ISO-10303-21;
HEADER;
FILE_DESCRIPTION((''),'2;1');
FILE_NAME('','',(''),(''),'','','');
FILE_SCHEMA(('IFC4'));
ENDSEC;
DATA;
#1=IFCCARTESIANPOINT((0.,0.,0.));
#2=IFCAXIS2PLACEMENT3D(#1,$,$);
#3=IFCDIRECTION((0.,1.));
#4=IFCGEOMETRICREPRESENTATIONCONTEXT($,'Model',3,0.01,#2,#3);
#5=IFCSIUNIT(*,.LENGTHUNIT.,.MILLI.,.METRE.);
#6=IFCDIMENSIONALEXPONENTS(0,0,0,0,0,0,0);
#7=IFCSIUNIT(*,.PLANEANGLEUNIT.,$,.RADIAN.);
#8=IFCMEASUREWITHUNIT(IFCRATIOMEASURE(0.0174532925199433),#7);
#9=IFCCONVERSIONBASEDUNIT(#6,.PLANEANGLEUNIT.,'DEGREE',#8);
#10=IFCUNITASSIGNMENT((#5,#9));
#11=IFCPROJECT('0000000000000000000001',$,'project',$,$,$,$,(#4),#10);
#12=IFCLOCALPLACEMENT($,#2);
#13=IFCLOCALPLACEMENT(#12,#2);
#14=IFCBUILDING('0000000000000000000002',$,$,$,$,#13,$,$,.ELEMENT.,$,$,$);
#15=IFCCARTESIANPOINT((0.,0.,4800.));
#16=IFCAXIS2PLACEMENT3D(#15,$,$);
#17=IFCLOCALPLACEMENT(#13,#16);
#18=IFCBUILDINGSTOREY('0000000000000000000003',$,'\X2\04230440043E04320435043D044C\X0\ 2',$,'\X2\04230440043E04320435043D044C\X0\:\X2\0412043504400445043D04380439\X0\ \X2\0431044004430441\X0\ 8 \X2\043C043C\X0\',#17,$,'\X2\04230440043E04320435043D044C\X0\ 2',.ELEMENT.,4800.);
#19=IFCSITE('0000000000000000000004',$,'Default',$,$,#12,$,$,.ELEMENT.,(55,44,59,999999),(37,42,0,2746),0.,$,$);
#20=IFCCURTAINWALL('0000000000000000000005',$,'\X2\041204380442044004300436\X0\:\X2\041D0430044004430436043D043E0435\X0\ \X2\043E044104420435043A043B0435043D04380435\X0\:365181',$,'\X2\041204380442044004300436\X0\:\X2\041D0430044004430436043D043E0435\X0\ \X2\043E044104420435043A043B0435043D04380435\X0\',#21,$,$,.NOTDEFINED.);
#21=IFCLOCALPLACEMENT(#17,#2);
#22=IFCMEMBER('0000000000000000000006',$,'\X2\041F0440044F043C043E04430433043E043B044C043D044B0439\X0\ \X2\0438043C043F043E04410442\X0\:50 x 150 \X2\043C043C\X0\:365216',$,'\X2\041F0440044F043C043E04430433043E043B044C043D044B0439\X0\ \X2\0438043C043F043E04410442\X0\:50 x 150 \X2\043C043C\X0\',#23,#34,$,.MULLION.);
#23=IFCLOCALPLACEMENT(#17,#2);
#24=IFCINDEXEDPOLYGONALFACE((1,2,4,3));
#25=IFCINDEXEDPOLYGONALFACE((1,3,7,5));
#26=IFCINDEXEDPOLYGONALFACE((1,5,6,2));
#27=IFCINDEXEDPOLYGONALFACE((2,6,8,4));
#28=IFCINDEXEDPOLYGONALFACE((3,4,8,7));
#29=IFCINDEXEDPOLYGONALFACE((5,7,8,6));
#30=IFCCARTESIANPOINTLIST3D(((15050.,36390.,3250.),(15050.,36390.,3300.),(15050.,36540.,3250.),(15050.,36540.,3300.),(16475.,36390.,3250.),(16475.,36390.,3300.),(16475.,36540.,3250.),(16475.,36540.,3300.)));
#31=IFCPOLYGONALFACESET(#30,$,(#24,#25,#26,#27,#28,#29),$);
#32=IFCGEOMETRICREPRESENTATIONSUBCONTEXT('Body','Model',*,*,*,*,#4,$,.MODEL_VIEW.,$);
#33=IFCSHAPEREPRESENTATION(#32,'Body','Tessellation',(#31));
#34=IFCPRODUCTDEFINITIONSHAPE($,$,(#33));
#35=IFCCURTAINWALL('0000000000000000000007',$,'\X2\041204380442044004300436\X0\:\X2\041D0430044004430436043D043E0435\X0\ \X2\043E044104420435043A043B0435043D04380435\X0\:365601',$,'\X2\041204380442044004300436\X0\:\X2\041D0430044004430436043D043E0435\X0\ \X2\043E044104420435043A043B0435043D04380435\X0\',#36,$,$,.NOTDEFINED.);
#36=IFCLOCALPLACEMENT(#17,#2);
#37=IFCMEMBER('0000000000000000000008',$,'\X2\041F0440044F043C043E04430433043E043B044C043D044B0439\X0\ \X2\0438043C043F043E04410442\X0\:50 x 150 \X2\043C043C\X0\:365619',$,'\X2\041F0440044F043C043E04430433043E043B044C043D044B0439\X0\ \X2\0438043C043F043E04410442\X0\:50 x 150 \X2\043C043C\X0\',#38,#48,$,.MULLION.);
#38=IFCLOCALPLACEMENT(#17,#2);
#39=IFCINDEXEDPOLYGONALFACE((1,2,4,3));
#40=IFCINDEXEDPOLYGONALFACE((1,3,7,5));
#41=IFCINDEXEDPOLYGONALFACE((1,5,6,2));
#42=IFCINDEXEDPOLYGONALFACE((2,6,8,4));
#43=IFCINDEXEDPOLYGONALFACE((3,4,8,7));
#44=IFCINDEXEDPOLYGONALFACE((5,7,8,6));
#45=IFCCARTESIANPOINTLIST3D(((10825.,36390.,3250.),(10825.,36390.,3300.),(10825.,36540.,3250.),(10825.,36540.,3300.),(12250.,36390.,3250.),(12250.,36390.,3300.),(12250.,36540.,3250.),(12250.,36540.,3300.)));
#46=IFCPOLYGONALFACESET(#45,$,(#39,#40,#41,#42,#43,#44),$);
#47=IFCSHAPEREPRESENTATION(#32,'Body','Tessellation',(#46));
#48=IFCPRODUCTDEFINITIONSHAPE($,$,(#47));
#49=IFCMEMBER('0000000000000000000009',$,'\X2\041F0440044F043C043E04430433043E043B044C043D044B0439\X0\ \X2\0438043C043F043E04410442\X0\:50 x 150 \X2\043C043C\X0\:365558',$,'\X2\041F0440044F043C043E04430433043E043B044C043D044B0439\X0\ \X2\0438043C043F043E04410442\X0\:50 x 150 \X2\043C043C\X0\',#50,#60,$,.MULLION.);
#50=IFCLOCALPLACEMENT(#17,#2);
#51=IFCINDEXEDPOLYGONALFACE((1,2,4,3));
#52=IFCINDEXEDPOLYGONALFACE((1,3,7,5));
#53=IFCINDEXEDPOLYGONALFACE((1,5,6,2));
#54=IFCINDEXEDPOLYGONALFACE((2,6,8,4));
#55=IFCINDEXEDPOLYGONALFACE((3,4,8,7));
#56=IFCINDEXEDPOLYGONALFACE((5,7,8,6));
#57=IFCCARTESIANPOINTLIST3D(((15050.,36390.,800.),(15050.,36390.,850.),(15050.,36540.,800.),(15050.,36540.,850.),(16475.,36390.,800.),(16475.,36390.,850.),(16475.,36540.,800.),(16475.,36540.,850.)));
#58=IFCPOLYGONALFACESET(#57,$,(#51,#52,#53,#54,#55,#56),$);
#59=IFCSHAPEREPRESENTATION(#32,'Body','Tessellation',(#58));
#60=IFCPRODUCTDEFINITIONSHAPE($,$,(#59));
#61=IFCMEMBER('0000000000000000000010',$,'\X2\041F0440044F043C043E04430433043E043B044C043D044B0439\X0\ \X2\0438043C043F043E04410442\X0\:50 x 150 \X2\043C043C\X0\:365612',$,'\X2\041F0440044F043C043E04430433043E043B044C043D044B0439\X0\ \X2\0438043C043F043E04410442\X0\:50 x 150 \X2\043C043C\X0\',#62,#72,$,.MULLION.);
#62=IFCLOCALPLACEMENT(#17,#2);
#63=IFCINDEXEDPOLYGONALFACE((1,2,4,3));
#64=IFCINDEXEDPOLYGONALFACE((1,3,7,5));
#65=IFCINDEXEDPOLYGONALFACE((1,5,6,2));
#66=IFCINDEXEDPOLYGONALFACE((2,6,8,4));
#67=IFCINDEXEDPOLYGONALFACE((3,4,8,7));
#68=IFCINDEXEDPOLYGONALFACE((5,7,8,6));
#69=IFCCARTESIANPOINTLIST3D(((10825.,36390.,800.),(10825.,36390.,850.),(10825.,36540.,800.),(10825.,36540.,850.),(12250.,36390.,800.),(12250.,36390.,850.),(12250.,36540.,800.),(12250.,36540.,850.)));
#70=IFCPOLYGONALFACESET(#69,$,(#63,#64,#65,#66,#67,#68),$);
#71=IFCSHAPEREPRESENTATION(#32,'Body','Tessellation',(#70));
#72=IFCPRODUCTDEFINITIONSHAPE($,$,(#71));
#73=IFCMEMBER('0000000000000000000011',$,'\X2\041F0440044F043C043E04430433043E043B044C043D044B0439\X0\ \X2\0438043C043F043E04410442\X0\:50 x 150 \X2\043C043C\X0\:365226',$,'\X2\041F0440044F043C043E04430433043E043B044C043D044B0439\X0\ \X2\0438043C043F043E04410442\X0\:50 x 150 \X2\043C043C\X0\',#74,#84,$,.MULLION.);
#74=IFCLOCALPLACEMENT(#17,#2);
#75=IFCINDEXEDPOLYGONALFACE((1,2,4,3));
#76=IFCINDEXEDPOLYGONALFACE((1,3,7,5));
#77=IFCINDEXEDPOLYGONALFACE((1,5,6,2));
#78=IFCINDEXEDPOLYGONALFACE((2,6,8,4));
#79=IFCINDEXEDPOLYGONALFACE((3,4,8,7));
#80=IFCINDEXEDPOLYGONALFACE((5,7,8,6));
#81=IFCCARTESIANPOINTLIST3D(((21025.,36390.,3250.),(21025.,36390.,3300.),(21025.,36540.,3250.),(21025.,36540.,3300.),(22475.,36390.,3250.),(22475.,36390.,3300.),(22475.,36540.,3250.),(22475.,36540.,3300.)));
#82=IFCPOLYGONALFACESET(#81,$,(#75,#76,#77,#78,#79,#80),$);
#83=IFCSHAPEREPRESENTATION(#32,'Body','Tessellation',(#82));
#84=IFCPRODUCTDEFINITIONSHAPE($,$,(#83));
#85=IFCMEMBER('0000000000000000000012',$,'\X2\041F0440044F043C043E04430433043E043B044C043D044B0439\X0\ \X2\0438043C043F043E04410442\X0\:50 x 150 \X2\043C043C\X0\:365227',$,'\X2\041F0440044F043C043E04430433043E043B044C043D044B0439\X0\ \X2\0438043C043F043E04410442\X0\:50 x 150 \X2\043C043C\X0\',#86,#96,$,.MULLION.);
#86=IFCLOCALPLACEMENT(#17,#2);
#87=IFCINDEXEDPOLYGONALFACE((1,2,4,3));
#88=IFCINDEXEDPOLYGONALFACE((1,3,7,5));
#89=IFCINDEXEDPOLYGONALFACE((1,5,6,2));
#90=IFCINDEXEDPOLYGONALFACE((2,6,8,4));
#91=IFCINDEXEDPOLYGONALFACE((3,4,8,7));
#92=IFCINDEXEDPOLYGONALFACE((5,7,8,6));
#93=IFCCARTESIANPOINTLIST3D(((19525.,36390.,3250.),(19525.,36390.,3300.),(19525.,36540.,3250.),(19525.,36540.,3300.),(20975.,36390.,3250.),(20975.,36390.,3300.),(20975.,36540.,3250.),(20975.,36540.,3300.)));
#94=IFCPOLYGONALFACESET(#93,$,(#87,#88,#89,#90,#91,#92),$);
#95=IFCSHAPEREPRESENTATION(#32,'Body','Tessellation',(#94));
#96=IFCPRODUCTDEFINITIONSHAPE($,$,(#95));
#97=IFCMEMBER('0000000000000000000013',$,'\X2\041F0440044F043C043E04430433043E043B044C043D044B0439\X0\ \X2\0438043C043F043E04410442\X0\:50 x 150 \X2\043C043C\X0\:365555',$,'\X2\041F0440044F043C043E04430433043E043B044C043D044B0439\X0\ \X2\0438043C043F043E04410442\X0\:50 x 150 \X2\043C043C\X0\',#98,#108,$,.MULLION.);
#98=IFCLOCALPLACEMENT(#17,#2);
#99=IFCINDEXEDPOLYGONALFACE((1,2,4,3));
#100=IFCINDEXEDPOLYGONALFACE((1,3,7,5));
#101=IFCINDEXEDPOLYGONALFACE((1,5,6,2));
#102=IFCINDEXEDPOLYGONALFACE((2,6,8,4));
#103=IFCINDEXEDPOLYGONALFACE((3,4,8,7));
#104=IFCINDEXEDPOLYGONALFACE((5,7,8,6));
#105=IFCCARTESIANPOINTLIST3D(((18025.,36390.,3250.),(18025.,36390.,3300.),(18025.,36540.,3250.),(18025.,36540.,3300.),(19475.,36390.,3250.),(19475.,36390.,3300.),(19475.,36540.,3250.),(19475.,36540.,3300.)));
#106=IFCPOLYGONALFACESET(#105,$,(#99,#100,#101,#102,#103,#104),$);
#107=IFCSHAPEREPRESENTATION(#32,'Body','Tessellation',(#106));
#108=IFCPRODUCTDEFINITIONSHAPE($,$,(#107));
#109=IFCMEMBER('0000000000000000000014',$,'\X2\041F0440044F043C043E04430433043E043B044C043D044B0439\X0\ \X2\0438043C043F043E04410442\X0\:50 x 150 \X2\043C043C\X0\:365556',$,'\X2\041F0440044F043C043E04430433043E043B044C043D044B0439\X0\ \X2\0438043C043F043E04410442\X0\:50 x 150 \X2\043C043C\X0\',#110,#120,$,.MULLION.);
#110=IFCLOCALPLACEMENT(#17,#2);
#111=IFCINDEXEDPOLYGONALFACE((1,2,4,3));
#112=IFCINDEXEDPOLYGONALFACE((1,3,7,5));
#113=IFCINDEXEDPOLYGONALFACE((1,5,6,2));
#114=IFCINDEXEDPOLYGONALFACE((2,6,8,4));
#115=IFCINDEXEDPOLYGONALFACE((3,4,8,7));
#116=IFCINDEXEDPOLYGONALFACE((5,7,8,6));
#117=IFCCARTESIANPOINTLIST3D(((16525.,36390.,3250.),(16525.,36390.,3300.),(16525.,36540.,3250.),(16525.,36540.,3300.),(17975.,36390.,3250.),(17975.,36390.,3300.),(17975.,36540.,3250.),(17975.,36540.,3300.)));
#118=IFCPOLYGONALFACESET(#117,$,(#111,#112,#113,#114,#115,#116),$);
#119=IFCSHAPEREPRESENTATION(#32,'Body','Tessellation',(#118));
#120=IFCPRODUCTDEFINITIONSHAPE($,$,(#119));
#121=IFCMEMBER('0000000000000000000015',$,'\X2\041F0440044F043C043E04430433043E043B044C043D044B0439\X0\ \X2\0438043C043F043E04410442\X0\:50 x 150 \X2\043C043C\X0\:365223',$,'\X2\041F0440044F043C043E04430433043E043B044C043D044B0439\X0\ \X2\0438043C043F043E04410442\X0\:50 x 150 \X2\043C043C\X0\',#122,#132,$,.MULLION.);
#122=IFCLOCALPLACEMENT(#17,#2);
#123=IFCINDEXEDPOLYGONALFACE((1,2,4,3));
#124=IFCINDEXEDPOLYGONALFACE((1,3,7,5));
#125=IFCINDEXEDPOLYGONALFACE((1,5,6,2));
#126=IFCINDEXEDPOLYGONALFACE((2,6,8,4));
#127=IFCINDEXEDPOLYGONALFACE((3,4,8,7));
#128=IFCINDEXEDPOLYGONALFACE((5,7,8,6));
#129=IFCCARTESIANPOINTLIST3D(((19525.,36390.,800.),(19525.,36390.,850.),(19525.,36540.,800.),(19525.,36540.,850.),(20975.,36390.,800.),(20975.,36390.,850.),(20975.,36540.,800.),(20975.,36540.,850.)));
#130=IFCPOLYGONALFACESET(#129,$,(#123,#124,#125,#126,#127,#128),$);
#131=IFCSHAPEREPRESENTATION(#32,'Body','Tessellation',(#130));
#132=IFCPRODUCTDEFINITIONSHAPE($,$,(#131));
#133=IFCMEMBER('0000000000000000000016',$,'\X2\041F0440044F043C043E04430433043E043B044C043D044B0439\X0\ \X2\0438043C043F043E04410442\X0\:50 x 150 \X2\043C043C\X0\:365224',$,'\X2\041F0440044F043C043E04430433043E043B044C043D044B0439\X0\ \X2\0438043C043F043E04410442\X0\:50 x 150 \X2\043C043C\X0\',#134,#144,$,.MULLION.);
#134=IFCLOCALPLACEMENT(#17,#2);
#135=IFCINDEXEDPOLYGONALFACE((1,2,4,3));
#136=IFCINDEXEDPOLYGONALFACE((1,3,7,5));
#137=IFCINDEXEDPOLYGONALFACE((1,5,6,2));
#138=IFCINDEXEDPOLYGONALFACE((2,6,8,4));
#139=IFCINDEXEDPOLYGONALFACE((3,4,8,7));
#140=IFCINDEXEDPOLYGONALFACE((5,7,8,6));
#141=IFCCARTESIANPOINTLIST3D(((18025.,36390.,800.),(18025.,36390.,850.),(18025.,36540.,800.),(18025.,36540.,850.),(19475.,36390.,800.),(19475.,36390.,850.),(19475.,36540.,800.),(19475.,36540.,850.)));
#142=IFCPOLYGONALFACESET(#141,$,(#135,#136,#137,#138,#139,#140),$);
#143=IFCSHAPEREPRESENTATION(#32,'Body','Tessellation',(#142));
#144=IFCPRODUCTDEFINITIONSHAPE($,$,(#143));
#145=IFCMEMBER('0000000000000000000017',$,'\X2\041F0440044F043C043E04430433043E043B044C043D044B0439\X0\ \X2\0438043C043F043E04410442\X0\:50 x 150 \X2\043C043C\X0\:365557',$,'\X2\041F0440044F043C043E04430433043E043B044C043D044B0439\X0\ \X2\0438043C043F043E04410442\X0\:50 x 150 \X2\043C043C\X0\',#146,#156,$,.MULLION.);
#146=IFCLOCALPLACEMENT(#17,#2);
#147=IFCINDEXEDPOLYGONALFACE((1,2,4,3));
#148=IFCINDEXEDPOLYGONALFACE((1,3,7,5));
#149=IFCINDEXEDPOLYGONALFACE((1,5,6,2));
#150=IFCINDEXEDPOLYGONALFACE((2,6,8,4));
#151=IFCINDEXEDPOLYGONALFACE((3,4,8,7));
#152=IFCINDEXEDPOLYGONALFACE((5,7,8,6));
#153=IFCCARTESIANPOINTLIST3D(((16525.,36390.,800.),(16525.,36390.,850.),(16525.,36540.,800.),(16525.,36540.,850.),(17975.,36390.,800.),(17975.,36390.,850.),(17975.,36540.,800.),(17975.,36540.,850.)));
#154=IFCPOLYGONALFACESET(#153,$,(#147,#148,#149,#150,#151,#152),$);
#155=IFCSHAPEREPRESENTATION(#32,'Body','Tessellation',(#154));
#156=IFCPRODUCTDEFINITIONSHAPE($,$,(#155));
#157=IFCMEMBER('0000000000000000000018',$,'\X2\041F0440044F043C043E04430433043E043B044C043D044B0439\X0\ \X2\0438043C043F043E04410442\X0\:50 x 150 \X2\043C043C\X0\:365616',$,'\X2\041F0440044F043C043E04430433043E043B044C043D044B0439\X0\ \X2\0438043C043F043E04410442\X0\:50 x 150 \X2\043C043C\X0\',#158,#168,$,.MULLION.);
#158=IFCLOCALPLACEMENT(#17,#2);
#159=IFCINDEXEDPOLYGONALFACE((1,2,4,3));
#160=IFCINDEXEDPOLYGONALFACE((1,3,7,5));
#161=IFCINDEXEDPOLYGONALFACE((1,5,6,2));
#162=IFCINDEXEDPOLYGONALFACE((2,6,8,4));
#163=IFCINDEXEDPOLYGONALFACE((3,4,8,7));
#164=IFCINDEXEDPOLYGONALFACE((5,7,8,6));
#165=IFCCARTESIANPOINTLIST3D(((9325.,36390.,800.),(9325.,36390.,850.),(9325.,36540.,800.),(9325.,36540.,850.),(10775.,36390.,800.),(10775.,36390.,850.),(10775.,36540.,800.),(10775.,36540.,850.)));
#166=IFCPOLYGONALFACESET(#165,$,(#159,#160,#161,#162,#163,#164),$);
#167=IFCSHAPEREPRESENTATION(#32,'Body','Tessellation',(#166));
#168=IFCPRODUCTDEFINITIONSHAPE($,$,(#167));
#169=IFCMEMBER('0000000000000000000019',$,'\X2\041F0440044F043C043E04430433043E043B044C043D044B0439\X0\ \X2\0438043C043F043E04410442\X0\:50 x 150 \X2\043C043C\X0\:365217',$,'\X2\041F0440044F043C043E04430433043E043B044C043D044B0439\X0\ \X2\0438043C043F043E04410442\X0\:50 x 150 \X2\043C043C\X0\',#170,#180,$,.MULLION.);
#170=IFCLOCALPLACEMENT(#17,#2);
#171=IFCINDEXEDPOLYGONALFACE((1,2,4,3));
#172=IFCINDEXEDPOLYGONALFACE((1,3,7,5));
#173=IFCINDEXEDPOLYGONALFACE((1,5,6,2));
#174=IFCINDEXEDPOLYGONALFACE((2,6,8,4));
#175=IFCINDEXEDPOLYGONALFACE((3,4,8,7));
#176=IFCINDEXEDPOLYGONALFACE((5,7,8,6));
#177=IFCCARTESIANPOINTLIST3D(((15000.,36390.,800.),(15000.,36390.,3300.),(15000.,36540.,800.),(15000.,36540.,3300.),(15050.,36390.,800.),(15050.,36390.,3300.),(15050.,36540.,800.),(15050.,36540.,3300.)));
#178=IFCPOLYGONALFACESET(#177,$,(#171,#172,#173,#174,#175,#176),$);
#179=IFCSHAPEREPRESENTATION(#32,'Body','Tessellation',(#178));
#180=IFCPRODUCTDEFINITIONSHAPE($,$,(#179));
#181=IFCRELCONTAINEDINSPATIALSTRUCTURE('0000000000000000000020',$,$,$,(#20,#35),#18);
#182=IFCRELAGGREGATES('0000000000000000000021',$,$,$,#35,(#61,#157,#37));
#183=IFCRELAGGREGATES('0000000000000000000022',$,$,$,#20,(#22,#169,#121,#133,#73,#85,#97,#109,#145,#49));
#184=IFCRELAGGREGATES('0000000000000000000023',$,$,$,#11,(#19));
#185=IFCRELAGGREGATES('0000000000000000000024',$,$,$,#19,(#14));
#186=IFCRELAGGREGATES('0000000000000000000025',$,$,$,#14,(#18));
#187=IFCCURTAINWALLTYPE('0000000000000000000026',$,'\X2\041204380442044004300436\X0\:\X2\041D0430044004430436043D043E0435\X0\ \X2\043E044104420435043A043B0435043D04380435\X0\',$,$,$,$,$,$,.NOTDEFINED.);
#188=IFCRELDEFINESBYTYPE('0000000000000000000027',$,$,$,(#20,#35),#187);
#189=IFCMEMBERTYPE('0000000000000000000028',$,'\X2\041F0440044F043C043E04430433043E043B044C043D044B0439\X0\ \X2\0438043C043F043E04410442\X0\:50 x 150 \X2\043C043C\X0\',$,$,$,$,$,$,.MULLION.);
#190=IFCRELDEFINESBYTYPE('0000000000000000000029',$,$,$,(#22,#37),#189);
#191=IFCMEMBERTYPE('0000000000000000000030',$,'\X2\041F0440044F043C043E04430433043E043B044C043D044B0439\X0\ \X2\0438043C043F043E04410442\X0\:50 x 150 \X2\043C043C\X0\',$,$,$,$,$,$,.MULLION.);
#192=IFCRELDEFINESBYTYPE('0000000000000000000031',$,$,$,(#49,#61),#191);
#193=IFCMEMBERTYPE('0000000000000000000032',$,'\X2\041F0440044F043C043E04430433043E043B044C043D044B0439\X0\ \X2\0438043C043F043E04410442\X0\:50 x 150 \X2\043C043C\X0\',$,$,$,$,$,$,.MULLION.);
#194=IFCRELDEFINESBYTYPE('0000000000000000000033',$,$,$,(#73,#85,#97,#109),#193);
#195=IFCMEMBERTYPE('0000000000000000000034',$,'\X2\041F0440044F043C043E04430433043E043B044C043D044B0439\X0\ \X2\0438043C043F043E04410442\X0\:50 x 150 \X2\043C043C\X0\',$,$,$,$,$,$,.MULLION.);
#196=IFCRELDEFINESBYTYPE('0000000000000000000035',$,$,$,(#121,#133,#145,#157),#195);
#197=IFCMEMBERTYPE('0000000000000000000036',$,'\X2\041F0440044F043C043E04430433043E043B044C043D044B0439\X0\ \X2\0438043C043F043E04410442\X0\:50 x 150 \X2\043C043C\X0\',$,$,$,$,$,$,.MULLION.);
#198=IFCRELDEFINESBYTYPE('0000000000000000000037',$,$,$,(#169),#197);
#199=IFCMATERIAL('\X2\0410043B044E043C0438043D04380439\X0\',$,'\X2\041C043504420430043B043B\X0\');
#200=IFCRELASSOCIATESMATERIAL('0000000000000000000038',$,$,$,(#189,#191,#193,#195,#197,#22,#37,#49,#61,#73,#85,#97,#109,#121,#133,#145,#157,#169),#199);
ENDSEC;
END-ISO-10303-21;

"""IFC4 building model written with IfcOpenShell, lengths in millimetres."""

from ifc_helpers import new_model, entity, si_unit, converted_unit, direction, frame, origin, origin_2d_with_axis, place, context, subcontext, project, spatial, rectangle, extrude, source, transform, mapped, material, material_profile, profile_set, profile_usage, type_object, type_shapes, element, aggregate, save


model = new_model("IFC4")

# Units and contexts
model_context = context("Model", 3, precision=0.01, world=origin(), true_north=direction((0.0, 1.0)))
body_context = subcontext(model_context, "Body", "Model", "MODEL_VIEW")
ifc_project = project(units=[si_unit("LENGTHUNIT", "METRE", prefix="MILLI"), converted_unit("PLANEANGLEUNIT", "DEGREE", entity("IfcRatioMeasure", 0.0174532925199433), si_unit("PLANEANGLEUNIT", "RADIAN"), dimensions=[0, 0, 0, 0, 0, 0, 0])], contexts=[model_context])

# Site, building, storey
site_placement = place(None, origin())
site = spatial("IfcSite", under=ifc_project, at=site_placement, Name="Default", CompositionType="ELEMENT", RefLatitude=(55, 44, 59, 999999), RefLongitude=(37, 42, 0, 2746), RefElevation=0.0)
building_placement = place(site_placement, origin())
building = spatial("IfcBuilding", under=site, at=building_placement, CompositionType="ELEMENT")
storey_placement = place(building_placement, frame((0.0, 0.0, 4800.0)))
storey = spatial("IfcBuildingStorey", under=building, at=storey_placement, Name="Уровень 2", ObjectType="Уровень:Верхний брус 8 мм", LongName="Уровень 2", CompositionType="ELEMENT", Elevation=4800.0)

# Curtain walls, members
curtain_wall_type = type_object("IfcCurtainWallType", Name="Витраж:Наружное остекление", PredefinedType="NOTDEFINED")
curtain_wall_1_placement = place(storey_placement, frame((0.0, 0.0, -4800.0)))
curtain_wall_1 = element("IfcCurtainWall", 1, at=curtain_wall_1_placement, inside=storey, type_object=curtain_wall_type, Name="Витраж:Наружное остекление:365181", ObjectType="Витраж:Наружное остекление", PredefinedType="NOTDEFINED")
ifc_material_1 = material(Name="Алюминий", Category="Металл")
ifc_material_profile = material_profile(ifc_material_1, rectangle(XDim=150.0, YDim=50.0, at=origin_2d_with_axis()), Name="50 x 150 мм")
ifc_profile_set = profile_set([ifc_material_profile], Name="50 x 150 мм")
ifc_profile_usage_1 = profile_usage(ifc_profile_set)
member_type_1 = type_object("IfcMemberType", Name="Прямоугольный импост:50 x 150 мм", PredefinedType="MULLION", material=ifc_profile_set)
shared_shape_1 = source(origin(), body_context, "Body", "SweptSolid", [
    extrude(rectangle(XDim=150.0, YDim=50.0, at=origin_2d_with_axis()), frame((-25.0, 0.0, -1425.0), z_axis=(0.0, 0.0, 1.0), x_axis=(0.0, -1.0, 0.0)), (0.0, 0.0, 1.0), 1425.0),
])
type_shapes(member_type_1, [shared_shape_1])
member_1_placement = place(storey_placement, frame((15050.0, 36465.0, 3300.0), z_axis=(-1.0, 0.0, 0.0), x_axis=(0.0, 0.0, 1.0)))
member_1 = element("IfcMember", 2, at=member_1_placement, type_object=member_type_1, material=ifc_profile_usage_1, Name="Прямоугольный импост:50 x 150 мм:365216", ObjectType="Прямоугольный импост:50 x 150 мм", PredefinedType="MULLION", context=body_context, shape_type="MappedRepresentation", body=[
    mapped(shared_shape_1, transform((0.0, 0.0, 0.0), scale=1.0)),
])
curtain_wall_2_placement = place(storey_placement, frame((0.0, 0.0, -4800.0)))
curtain_wall_2 = element("IfcCurtainWall", 3, at=curtain_wall_2_placement, inside=storey, type_object=curtain_wall_type, Name="Витраж:Наружное остекление:365601", ObjectType="Витраж:Наружное остекление", PredefinedType="NOTDEFINED")
ifc_profile_usage_2 = profile_usage(ifc_profile_set)
member_2_placement = place(storey_placement, frame((10825.0, 36465.0, 3300.0), z_axis=(-1.0, 0.0, 0.0), x_axis=(0.0, 0.0, 1.0)))
member_2 = element("IfcMember", 4, at=member_2_placement, type_object=member_type_1, material=ifc_profile_usage_2, Name="Прямоугольный импост:50 x 150 мм:365619", ObjectType="Прямоугольный импост:50 x 150 мм", PredefinedType="MULLION", context=body_context, shape_type="MappedRepresentation", body=[
    mapped(shared_shape_1, transform((0.0, 0.0, 0.0), scale=1.0)),
])

# Members
ifc_profile_usage_3 = profile_usage(ifc_profile_set)
member_type_2 = type_object("IfcMemberType", Name="Прямоугольный импост:50 x 150 мм", PredefinedType="MULLION", material=ifc_profile_set)
shared_shape_2 = source(origin(), body_context, "Body", "SweptSolid", [
    extrude(rectangle(XDim=150.0, YDim=50.0, at=origin_2d_with_axis()), frame((-25.0, 0.0, -1425.0), z_axis=(0.0, 0.0, 1.0), x_axis=(0.0, -1.0, 0.0)), (0.0, 0.0, 1.0), 1425.0),
])
type_shapes(member_type_2, [shared_shape_2])
member_3_placement = place(storey_placement, frame((16475.0, 36465.0, 800.0), z_axis=(1.0, 0.0, 0.0), x_axis=(0.0, 0.0, -1.0)))
member_3 = element("IfcMember", 5, at=member_3_placement, type_object=member_type_2, material=ifc_profile_usage_3, Name="Прямоугольный импост:50 x 150 мм:365558", ObjectType="Прямоугольный импост:50 x 150 мм", PredefinedType="MULLION", context=body_context, shape_type="MappedRepresentation", body=[
    mapped(shared_shape_2, transform((0.0, 0.0, 0.0), scale=1.0)),
])
ifc_profile_usage_4 = profile_usage(ifc_profile_set)
member_4_placement = place(storey_placement, frame((12250.0, 36465.0, 800.0), z_axis=(1.0, 0.0, 0.0), x_axis=(0.0, 0.0, -1.0)))
member_4 = element("IfcMember", 6, at=member_4_placement, type_object=member_type_2, material=ifc_profile_usage_4, Name="Прямоугольный импост:50 x 150 мм:365612", ObjectType="Прямоугольный импост:50 x 150 мм", PredefinedType="MULLION", context=body_context, shape_type="MappedRepresentation", body=[
    mapped(shared_shape_2, transform((0.0, 0.0, 0.0), scale=1.0)),
])
ifc_profile_usage_5 = profile_usage(ifc_profile_set)
member_type_3 = type_object("IfcMemberType", Name="Прямоугольный импост:50 x 150 мм", PredefinedType="MULLION", material=ifc_profile_set)
shared_shape_3 = source(origin(), body_context, "Body", "SweptSolid", [
    extrude(rectangle(XDim=150.0, YDim=50.0, at=origin_2d_with_axis()), frame((-25.0, 0.0, -1450.0), z_axis=(0.0, 0.0, 1.0), x_axis=(0.0, -1.0, 0.0)), (0.0, 0.0, 1.0), 1450.0),
])
type_shapes(member_type_3, [shared_shape_3])
member_5_placement = place(storey_placement, frame((21025.0, 36465.0, 3300.0), z_axis=(-1.0, 0.0, 0.0), x_axis=(0.0, 0.0, 1.0)))
member_5 = element("IfcMember", 7, at=member_5_placement, type_object=member_type_3, material=ifc_profile_usage_5, Name="Прямоугольный импост:50 x 150 мм:365226", ObjectType="Прямоугольный импост:50 x 150 мм", PredefinedType="MULLION", context=body_context, shape_type="MappedRepresentation", body=[
    mapped(shared_shape_3, transform((0.0, 0.0, 0.0), scale=1.0)),
])
ifc_profile_usage_6 = profile_usage(ifc_profile_set)
member_6_placement = place(storey_placement, frame((19525.0, 36465.0, 3300.0), z_axis=(-1.0, 0.0, 0.0), x_axis=(0.0, 0.0, 1.0)))
member_6 = element("IfcMember", 8, at=member_6_placement, type_object=member_type_3, material=ifc_profile_usage_6, Name="Прямоугольный импост:50 x 150 мм:365227", ObjectType="Прямоугольный импост:50 x 150 мм", PredefinedType="MULLION", context=body_context, shape_type="MappedRepresentation", body=[
    mapped(shared_shape_3, transform((0.0, 0.0, 0.0), scale=1.0)),
])
ifc_profile_usage_7 = profile_usage(ifc_profile_set)
member_7_placement = place(storey_placement, frame((18025.0, 36465.0, 3300.0), z_axis=(-1.0, 0.0, 0.0), x_axis=(0.0, 0.0, 1.0)))
member_7 = element("IfcMember", 9, at=member_7_placement, type_object=member_type_3, material=ifc_profile_usage_7, Name="Прямоугольный импост:50 x 150 мм:365555", ObjectType="Прямоугольный импост:50 x 150 мм", PredefinedType="MULLION", context=body_context, shape_type="MappedRepresentation", body=[
    mapped(shared_shape_3, transform((0.0, 0.0, 0.0), scale=1.0)),
])
ifc_profile_usage_8 = profile_usage(ifc_profile_set)
member_8_placement = place(storey_placement, frame((16525.0, 36465.0, 3300.0), z_axis=(-1.0, 0.0, 0.0), x_axis=(0.0, 0.0, 1.0)))
member_8 = element("IfcMember", 10, at=member_8_placement, type_object=member_type_3, material=ifc_profile_usage_8, Name="Прямоугольный импост:50 x 150 мм:365556", ObjectType="Прямоугольный импост:50 x 150 мм", PredefinedType="MULLION", context=body_context, shape_type="MappedRepresentation", body=[
    mapped(shared_shape_3, transform((0.0, 0.0, 0.0), scale=1.0)),
])
ifc_profile_usage_9 = profile_usage(ifc_profile_set)
member_type_4 = type_object("IfcMemberType", Name="Прямоугольный импост:50 x 150 мм", PredefinedType="MULLION", material=ifc_profile_set)
shared_shape_4 = source(origin(), body_context, "Body", "SweptSolid", [
    extrude(rectangle(XDim=150.0, YDim=50.0, at=origin_2d_with_axis()), frame((-25.0, 0.0, -1450.0), z_axis=(0.0, 0.0, 1.0), x_axis=(0.0, -1.0, 0.0)), (0.0, 0.0, 1.0), 1450.0),
])
type_shapes(member_type_4, [shared_shape_4])
member_9_placement = place(storey_placement, frame((20975.0, 36465.0, 800.0), z_axis=(1.0, 0.0, 0.0), x_axis=(0.0, 0.0, -1.0)))
member_9 = element("IfcMember", 11, at=member_9_placement, type_object=member_type_4, material=ifc_profile_usage_9, Name="Прямоугольный импост:50 x 150 мм:365223", ObjectType="Прямоугольный импост:50 x 150 мм", PredefinedType="MULLION", context=body_context, shape_type="MappedRepresentation", body=[
    mapped(shared_shape_4, transform((0.0, 0.0, 0.0), scale=1.0)),
])
ifc_profile_usage_10 = profile_usage(ifc_profile_set)
member_10_placement = place(storey_placement, frame((19475.0, 36465.0, 800.0), z_axis=(1.0, 0.0, 0.0), x_axis=(0.0, 0.0, -1.0)))
member_10 = element("IfcMember", 12, at=member_10_placement, type_object=member_type_4, material=ifc_profile_usage_10, Name="Прямоугольный импост:50 x 150 мм:365224", ObjectType="Прямоугольный импост:50 x 150 мм", PredefinedType="MULLION", context=body_context, shape_type="MappedRepresentation", body=[
    mapped(shared_shape_4, transform((0.0, 0.0, 0.0), scale=1.0)),
])
ifc_profile_usage_11 = profile_usage(ifc_profile_set)
member_11_placement = place(storey_placement, frame((17975.0, 36465.0, 800.0), z_axis=(1.0, 0.0, 0.0), x_axis=(0.0, 0.0, -1.0)))
member_11 = element("IfcMember", 13, at=member_11_placement, type_object=member_type_4, material=ifc_profile_usage_11, Name="Прямоугольный импост:50 x 150 мм:365557", ObjectType="Прямоугольный импост:50 x 150 мм", PredefinedType="MULLION", context=body_context, shape_type="MappedRepresentation", body=[
    mapped(shared_shape_4, transform((0.0, 0.0, 0.0), scale=1.0)),
])
ifc_profile_usage_12 = profile_usage(ifc_profile_set)
member_12_placement = place(storey_placement, frame((10775.0, 36465.0, 800.0), z_axis=(1.0, 0.0, 0.0), x_axis=(0.0, 0.0, -1.0)))
member_12 = element("IfcMember", 14, at=member_12_placement, type_object=member_type_4, material=ifc_profile_usage_12, Name="Прямоугольный импост:50 x 150 мм:365616", ObjectType="Прямоугольный импост:50 x 150 мм", PredefinedType="MULLION", context=body_context, shape_type="MappedRepresentation", body=[
    mapped(shared_shape_4, transform((0.0, 0.0, 0.0), scale=1.0)),
])
ifc_profile_usage_13 = profile_usage(ifc_profile_set)
member_type_5 = type_object("IfcMemberType", Name="Прямоугольный импост:50 x 150 мм", PredefinedType="MULLION", material=ifc_profile_set)
shared_shape_5 = source(origin(), body_context, "Body", "SweptSolid", [
    extrude(rectangle(XDim=150.0, YDim=50.0, at=origin_2d_with_axis()), frame((-25.0, 0.0, -2500.0), z_axis=(0.0, 0.0, 1.0), x_axis=(0.0, -1.0, 0.0)), (0.0, 0.0, 1.0), 2500.0),
])
type_shapes(member_type_5, [shared_shape_5])
member_13_placement = place(storey_placement, frame((15000.0, 36465.0, 800.0), z_axis=(0.0, 0.0, -1.0), x_axis=(-1.0, 0.0, 0.0)))
member_13 = element("IfcMember", 15, at=member_13_placement, type_object=member_type_5, material=ifc_profile_usage_13, Name="Прямоугольный импост:50 x 150 мм:365217", ObjectType="Прямоугольный импост:50 x 150 мм", PredefinedType="MULLION", context=body_context, shape_type="MappedRepresentation", body=[
    mapped(shared_shape_5, transform((0.0, 0.0, 0.0), scale=1.0)),
])
aggregate(curtain_wall_2, [member_4, member_12, member_2])

aggregate(curtain_wall_1, [member_1, member_13, member_9, member_10, member_5, member_6, member_7, member_8, member_11, member_3])

save(model, "model.ifc")
